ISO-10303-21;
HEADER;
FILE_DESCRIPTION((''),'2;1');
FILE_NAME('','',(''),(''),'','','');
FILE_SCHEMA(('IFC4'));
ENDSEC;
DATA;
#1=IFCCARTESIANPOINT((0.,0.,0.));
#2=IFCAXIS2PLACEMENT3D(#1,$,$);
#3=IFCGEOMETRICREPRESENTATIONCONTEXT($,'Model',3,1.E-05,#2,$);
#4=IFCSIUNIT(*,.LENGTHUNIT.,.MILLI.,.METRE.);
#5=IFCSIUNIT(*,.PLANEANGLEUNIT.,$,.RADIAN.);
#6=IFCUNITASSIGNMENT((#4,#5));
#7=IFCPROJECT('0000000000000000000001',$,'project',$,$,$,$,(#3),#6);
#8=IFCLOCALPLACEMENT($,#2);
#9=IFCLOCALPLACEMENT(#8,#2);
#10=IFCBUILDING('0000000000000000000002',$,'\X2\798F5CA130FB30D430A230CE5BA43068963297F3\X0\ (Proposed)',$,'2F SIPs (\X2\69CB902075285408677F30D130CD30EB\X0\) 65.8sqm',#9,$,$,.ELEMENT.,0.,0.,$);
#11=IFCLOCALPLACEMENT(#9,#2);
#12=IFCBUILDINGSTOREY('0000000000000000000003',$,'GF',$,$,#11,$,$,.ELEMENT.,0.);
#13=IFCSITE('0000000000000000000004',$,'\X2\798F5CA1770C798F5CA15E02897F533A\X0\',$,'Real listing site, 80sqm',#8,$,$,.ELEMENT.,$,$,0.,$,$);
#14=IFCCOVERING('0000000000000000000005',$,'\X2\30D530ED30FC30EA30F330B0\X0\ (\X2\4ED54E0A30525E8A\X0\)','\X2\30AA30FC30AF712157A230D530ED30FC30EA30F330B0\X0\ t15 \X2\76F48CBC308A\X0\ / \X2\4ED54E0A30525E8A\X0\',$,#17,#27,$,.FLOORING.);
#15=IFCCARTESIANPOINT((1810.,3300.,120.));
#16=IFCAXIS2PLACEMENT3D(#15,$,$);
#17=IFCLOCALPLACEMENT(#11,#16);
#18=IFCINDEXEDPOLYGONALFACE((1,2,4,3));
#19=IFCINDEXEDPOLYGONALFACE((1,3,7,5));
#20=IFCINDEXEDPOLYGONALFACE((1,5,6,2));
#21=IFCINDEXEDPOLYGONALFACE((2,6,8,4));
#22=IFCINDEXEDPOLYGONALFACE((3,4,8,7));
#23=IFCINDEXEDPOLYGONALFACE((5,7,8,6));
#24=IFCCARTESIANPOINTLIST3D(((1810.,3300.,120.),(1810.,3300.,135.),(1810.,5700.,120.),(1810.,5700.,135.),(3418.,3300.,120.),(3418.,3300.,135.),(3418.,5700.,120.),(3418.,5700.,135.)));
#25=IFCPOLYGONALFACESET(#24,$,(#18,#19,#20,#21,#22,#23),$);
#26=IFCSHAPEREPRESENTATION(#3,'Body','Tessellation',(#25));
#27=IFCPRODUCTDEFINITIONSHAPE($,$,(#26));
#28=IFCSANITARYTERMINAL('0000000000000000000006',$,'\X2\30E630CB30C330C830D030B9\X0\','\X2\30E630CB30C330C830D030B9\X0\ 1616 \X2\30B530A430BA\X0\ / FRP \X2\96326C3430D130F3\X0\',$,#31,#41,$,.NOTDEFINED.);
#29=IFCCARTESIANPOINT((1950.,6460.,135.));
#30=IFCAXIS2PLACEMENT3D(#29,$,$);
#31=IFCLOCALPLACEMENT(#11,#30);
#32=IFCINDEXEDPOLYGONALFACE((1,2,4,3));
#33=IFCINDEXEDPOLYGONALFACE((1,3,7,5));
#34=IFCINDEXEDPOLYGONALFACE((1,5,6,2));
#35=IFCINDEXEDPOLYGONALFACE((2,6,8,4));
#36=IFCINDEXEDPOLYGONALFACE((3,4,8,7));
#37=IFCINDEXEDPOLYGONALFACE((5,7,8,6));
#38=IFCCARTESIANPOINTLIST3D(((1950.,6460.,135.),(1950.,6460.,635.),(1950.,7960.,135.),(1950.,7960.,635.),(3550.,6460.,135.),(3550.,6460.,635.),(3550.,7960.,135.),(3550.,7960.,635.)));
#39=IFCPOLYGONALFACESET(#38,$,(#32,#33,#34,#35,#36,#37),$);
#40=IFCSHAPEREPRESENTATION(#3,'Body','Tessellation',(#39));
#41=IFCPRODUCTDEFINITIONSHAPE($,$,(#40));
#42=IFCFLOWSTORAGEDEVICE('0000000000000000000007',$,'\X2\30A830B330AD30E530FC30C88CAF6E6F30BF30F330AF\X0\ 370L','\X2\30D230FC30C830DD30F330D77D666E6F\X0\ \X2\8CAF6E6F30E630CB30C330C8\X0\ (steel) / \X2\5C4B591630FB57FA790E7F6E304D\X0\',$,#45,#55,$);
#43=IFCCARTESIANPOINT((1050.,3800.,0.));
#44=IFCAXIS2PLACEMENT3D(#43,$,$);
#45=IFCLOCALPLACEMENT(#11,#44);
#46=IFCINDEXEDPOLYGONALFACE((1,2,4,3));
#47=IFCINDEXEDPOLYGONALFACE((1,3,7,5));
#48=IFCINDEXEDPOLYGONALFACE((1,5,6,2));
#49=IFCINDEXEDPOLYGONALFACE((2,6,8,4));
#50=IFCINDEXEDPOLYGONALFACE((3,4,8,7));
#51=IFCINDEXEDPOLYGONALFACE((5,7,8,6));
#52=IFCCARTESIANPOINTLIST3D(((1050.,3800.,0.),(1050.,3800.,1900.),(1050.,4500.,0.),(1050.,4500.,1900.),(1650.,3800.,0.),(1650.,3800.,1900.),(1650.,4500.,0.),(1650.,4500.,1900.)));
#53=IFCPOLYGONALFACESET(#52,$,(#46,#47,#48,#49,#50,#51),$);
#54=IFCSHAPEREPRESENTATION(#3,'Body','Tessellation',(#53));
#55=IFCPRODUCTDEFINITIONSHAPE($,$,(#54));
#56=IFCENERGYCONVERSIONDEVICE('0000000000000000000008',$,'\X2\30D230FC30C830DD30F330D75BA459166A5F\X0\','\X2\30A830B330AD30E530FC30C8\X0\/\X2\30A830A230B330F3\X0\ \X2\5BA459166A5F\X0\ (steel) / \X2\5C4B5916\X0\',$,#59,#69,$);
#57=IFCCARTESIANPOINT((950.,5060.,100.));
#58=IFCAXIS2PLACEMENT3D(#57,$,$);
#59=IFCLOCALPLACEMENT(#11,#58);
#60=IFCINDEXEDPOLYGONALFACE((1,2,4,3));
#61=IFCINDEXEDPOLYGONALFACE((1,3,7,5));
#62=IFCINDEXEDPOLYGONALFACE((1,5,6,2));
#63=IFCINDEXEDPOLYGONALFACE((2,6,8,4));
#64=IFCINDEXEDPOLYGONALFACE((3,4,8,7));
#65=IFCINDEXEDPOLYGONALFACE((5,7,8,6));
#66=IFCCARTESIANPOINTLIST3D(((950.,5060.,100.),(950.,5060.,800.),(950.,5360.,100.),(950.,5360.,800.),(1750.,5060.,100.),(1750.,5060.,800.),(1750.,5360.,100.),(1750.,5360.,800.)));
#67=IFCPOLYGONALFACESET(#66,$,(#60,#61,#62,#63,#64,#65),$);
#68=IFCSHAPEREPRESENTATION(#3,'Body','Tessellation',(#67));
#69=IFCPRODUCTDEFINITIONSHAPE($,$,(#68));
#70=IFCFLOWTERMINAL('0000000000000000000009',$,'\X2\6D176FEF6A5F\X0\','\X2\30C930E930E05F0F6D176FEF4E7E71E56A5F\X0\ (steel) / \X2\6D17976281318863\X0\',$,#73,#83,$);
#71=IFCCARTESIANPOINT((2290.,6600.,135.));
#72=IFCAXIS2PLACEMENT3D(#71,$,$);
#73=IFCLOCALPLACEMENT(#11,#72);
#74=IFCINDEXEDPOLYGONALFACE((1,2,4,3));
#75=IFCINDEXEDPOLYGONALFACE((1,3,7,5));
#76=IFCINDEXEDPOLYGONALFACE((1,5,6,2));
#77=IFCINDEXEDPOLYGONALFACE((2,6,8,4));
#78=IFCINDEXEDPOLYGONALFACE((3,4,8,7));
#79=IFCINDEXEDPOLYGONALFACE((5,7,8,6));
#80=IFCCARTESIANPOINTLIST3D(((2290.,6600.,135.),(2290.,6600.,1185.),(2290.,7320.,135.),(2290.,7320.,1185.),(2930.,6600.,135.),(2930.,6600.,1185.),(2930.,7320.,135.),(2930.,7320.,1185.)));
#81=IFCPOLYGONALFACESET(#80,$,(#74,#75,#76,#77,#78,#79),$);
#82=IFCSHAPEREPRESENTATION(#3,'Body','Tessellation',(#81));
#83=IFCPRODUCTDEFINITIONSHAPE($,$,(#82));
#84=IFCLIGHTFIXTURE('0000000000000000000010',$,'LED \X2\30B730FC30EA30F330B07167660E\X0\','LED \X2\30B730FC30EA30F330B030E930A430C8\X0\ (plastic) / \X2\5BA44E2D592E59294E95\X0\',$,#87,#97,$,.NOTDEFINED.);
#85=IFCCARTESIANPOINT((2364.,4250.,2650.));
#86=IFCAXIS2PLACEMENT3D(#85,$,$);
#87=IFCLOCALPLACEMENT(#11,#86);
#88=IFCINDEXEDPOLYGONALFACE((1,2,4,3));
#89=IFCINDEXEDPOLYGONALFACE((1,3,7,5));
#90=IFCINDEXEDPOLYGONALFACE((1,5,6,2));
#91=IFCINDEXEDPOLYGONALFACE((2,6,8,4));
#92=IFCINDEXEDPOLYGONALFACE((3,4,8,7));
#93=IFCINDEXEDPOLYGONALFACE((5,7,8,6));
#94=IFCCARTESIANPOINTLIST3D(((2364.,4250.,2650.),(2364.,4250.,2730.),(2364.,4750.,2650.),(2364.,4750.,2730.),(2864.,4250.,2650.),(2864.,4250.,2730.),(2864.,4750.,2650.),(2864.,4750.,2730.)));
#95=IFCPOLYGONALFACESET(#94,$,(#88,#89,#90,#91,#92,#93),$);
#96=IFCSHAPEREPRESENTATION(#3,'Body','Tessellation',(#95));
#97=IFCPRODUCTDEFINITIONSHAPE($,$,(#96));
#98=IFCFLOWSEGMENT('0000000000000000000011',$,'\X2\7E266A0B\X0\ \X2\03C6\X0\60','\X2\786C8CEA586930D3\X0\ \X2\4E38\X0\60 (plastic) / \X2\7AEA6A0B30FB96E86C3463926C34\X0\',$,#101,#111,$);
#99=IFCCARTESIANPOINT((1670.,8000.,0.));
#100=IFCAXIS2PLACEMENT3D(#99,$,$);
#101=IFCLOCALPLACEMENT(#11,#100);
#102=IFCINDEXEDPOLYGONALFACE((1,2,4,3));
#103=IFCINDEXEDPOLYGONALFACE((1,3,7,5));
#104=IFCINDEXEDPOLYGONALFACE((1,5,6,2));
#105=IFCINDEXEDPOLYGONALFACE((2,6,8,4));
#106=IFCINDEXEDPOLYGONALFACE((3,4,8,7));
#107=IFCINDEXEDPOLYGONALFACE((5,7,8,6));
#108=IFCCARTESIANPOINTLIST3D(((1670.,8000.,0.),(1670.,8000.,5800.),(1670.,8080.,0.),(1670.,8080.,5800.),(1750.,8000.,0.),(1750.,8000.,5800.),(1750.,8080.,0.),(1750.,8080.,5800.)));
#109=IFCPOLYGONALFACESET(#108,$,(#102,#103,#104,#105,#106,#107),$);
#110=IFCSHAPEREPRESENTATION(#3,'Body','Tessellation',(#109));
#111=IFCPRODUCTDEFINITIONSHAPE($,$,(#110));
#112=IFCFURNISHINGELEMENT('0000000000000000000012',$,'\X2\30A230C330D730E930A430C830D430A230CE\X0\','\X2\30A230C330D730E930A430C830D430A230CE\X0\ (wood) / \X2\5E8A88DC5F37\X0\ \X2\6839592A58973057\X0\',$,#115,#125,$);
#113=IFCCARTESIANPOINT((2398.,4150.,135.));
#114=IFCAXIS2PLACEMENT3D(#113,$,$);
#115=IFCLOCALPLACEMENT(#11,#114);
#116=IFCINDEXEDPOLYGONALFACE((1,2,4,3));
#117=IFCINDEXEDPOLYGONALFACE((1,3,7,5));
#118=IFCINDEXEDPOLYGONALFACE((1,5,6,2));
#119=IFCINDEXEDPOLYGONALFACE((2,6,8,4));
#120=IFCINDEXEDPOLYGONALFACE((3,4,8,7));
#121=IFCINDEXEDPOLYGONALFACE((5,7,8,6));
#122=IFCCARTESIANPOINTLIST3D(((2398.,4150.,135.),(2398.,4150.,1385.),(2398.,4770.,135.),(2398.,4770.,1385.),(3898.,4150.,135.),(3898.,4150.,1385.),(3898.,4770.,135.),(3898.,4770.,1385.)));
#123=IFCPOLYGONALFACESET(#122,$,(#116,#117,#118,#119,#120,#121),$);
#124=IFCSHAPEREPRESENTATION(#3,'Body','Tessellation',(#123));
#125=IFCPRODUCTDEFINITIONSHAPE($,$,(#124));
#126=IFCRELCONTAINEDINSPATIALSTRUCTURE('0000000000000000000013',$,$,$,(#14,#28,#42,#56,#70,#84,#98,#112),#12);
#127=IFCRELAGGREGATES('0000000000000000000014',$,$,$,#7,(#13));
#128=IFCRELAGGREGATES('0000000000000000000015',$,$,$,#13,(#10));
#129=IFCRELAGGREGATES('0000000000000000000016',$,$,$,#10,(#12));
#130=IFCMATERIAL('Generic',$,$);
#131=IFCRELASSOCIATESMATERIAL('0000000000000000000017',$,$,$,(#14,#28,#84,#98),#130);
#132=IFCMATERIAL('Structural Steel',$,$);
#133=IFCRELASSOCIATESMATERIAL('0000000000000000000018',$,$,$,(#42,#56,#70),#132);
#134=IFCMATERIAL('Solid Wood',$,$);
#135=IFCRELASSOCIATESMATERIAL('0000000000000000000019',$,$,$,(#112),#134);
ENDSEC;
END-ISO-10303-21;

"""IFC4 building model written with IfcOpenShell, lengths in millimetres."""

from ifc_helpers import new_model, si_unit, frame, frame_2d, origin, place, context, project, spatial, rectangle, extrude, material, element, save


model = new_model("IFC4")

# Units and contexts
model_context = context("Model", 3, precision=1e-05, world=origin())
ifc_project = project(units=[si_unit("LENGTHUNIT", "METRE", prefix="MILLI"), si_unit("PLANEANGLEUNIT", "RADIAN")], contexts=[model_context])

# Site, building, storey
site_placement = place(None, origin())
site = spatial("IfcSite", under=ifc_project, at=site_placement, Name="福岡県福岡市西区", ObjectType="Real listing site, 80sqm", CompositionType="ELEMENT", RefElevation=0.0)
building_placement = place(site_placement, origin())
building = spatial("IfcBuilding", under=site, at=building_placement, Name="福岡・ピアノ室と防音 (Proposed)", ObjectType="2F SIPs (構造用合板パネル) 65.8sqm", CompositionType="ELEMENT", ElevationOfRefHeight=0.0, ElevationOfTerrain=0.0)
storey_placement = place(building_placement, origin())
storey = spatial("IfcBuildingStorey", under=building, at=storey_placement, Name="GF", CompositionType="ELEMENT", Elevation=0.0)

# Shared definitions
ifc_material_1 = material(Name="Solid Wood")

# Covering
ifc_material_2 = material(Name="Generic")
covering_1_placement = place(storey_placement, frame((1810.0, 3300.0, 120.0)))
element("IfcCovering", 1, at=covering_1_placement, inside=storey, material=ifc_material_2, Name="フローリング (仕上げ床)", Description="オーク無垢フローリング t15 直貼り / 仕上げ床", PredefinedType="FLOORING", context=model_context, shape_type="SweptSolid", body=[
    extrude(rectangle(XDim=1608.0, YDim=2400.0, at=frame_2d((804.0, 1200.0))), frame((1810.0, 3300.0, 120.0)), (0.0, 0.0, 1.0), 15.0),
])

# Sanitary terminal
sanitary_terminal_placement = place(storey_placement, frame((1950.0, 6460.0, 135.0)))
element("IfcSanitaryTerminal", 2, at=sanitary_terminal_placement, inside=storey, material=ifc_material_2, Name="ユニットバス", Description="ユニットバス 1616 サイズ / FRP 防水パン", PredefinedType="NOTDEFINED", context=model_context, shape_type="SweptSolid", body=[
    extrude(rectangle(XDim=1600.0, YDim=1500.0, at=frame_2d((800.0, 750.0))), frame((1950.0, 6460.0, 135.0)), (0.0, 0.0, 1.0), 500.0),
])

# Flow storage device
ifc_material_3 = material(Name="Structural Steel")
flow_storage_device_placement = place(storey_placement, frame((1050.0, 3800.0, 0.0)))
element("IfcFlowStorageDevice", 3, at=flow_storage_device_placement, inside=storey, material=ifc_material_3, Name="エコキュート貯湯タンク 370L", Description="ヒートポンプ給湯 貯湯ユニット (steel) / 屋外・基礎置き", context=model_context, shape_type="SweptSolid", body=[
    extrude(rectangle(XDim=600.0, YDim=700.0, at=frame_2d((300.0, 350.0))), frame((1050.0, 3800.0, 0.0)), (0.0, 0.0, 1.0), 1900.0),
])

# Energy conversion device
energy_conversion_device_placement = place(storey_placement, frame((950.0, 5060.0, 100.0)))
element("IfcEnergyConversionDevice", 4, at=energy_conversion_device_placement, inside=storey, material=ifc_material_3, Name="ヒートポンプ室外機", Description="エコキュート/エアコン 室外機 (steel) / 屋外", context=model_context, shape_type="SweptSolid", body=[
    extrude(rectangle(XDim=800.0, YDim=300.0, at=frame_2d((400.0, 150.0))), frame((950.0, 5060.0, 100.0)), (0.0, 0.0, 1.0), 700.0),
])

# Flow terminal
flow_terminal_placement = place(storey_placement, frame((2290.0, 6600.0, 135.0)))
element("IfcFlowTerminal", 5, at=flow_terminal_placement, inside=storey, material=ifc_material_3, Name="洗濯機", Description="ドラム式洗濯乾燥機 (steel) / 洗面脱衣", context=model_context, shape_type="SweptSolid", body=[
    extrude(rectangle(XDim=640.0, YDim=720.0, at=frame_2d((320.0, 360.0))), frame((2290.0, 6600.0, 135.0)), (0.0, 0.0, 1.0), 1050.0),
])

# Light fixture
light_fixture_placement = place(storey_placement, frame((2364.0, 4250.0, 2650.0)))
element("IfcLightFixture", 6, at=light_fixture_placement, inside=storey, material=ifc_material_2, Name="LED シーリング照明", Description="LED シーリングライト (plastic) / 室中央天井", PredefinedType="NOTDEFINED", context=model_context, shape_type="SweptSolid", body=[
    extrude(rectangle(XDim=500.0, YDim=500.0, at=frame_2d((250.0, 250.0))), frame((2364.0, 4250.0, 2650.0)), (0.0, 0.0, 1.0), 80.0),
])

# Flow segment
flow_segment_placement = place(storey_placement, frame((1670.0, 8000.0, 0.0)))
element("IfcFlowSegment", 7, at=flow_segment_placement, inside=storey, material=ifc_material_2, Name="縦樋 φ60", Description="硬質塩ビ 丸60 (plastic) / 竪樋・雨水排水", context=model_context, shape_type="SweptSolid", body=[
    extrude(rectangle(XDim=80.0, YDim=80.0, at=frame_2d((40.0, 40.0))), frame((1670.0, 8000.0, 0.0)), (0.0, 0.0, 1.0), 5800.0),
])

# Furnishing element
furnishing_placement = place(storey_placement, frame((2398.0, 4150.0, 135.0)))
element("IfcFurnishingElement", 8, at=furnishing_placement, inside=storey, material=ifc_material_1, Name="アップライトピアノ", Description="アップライトピアノ (wood) / 床補強 根太増し", context=model_context, shape_type="SweptSolid", body=[
    extrude(rectangle(XDim=1500.0, YDim=620.0, at=frame_2d((750.0, 310.0))), frame((2398.0, 4150.0, 135.0)), (0.0, 0.0, 1.0), 1250.0),
])

save(model, "model.ifc")
